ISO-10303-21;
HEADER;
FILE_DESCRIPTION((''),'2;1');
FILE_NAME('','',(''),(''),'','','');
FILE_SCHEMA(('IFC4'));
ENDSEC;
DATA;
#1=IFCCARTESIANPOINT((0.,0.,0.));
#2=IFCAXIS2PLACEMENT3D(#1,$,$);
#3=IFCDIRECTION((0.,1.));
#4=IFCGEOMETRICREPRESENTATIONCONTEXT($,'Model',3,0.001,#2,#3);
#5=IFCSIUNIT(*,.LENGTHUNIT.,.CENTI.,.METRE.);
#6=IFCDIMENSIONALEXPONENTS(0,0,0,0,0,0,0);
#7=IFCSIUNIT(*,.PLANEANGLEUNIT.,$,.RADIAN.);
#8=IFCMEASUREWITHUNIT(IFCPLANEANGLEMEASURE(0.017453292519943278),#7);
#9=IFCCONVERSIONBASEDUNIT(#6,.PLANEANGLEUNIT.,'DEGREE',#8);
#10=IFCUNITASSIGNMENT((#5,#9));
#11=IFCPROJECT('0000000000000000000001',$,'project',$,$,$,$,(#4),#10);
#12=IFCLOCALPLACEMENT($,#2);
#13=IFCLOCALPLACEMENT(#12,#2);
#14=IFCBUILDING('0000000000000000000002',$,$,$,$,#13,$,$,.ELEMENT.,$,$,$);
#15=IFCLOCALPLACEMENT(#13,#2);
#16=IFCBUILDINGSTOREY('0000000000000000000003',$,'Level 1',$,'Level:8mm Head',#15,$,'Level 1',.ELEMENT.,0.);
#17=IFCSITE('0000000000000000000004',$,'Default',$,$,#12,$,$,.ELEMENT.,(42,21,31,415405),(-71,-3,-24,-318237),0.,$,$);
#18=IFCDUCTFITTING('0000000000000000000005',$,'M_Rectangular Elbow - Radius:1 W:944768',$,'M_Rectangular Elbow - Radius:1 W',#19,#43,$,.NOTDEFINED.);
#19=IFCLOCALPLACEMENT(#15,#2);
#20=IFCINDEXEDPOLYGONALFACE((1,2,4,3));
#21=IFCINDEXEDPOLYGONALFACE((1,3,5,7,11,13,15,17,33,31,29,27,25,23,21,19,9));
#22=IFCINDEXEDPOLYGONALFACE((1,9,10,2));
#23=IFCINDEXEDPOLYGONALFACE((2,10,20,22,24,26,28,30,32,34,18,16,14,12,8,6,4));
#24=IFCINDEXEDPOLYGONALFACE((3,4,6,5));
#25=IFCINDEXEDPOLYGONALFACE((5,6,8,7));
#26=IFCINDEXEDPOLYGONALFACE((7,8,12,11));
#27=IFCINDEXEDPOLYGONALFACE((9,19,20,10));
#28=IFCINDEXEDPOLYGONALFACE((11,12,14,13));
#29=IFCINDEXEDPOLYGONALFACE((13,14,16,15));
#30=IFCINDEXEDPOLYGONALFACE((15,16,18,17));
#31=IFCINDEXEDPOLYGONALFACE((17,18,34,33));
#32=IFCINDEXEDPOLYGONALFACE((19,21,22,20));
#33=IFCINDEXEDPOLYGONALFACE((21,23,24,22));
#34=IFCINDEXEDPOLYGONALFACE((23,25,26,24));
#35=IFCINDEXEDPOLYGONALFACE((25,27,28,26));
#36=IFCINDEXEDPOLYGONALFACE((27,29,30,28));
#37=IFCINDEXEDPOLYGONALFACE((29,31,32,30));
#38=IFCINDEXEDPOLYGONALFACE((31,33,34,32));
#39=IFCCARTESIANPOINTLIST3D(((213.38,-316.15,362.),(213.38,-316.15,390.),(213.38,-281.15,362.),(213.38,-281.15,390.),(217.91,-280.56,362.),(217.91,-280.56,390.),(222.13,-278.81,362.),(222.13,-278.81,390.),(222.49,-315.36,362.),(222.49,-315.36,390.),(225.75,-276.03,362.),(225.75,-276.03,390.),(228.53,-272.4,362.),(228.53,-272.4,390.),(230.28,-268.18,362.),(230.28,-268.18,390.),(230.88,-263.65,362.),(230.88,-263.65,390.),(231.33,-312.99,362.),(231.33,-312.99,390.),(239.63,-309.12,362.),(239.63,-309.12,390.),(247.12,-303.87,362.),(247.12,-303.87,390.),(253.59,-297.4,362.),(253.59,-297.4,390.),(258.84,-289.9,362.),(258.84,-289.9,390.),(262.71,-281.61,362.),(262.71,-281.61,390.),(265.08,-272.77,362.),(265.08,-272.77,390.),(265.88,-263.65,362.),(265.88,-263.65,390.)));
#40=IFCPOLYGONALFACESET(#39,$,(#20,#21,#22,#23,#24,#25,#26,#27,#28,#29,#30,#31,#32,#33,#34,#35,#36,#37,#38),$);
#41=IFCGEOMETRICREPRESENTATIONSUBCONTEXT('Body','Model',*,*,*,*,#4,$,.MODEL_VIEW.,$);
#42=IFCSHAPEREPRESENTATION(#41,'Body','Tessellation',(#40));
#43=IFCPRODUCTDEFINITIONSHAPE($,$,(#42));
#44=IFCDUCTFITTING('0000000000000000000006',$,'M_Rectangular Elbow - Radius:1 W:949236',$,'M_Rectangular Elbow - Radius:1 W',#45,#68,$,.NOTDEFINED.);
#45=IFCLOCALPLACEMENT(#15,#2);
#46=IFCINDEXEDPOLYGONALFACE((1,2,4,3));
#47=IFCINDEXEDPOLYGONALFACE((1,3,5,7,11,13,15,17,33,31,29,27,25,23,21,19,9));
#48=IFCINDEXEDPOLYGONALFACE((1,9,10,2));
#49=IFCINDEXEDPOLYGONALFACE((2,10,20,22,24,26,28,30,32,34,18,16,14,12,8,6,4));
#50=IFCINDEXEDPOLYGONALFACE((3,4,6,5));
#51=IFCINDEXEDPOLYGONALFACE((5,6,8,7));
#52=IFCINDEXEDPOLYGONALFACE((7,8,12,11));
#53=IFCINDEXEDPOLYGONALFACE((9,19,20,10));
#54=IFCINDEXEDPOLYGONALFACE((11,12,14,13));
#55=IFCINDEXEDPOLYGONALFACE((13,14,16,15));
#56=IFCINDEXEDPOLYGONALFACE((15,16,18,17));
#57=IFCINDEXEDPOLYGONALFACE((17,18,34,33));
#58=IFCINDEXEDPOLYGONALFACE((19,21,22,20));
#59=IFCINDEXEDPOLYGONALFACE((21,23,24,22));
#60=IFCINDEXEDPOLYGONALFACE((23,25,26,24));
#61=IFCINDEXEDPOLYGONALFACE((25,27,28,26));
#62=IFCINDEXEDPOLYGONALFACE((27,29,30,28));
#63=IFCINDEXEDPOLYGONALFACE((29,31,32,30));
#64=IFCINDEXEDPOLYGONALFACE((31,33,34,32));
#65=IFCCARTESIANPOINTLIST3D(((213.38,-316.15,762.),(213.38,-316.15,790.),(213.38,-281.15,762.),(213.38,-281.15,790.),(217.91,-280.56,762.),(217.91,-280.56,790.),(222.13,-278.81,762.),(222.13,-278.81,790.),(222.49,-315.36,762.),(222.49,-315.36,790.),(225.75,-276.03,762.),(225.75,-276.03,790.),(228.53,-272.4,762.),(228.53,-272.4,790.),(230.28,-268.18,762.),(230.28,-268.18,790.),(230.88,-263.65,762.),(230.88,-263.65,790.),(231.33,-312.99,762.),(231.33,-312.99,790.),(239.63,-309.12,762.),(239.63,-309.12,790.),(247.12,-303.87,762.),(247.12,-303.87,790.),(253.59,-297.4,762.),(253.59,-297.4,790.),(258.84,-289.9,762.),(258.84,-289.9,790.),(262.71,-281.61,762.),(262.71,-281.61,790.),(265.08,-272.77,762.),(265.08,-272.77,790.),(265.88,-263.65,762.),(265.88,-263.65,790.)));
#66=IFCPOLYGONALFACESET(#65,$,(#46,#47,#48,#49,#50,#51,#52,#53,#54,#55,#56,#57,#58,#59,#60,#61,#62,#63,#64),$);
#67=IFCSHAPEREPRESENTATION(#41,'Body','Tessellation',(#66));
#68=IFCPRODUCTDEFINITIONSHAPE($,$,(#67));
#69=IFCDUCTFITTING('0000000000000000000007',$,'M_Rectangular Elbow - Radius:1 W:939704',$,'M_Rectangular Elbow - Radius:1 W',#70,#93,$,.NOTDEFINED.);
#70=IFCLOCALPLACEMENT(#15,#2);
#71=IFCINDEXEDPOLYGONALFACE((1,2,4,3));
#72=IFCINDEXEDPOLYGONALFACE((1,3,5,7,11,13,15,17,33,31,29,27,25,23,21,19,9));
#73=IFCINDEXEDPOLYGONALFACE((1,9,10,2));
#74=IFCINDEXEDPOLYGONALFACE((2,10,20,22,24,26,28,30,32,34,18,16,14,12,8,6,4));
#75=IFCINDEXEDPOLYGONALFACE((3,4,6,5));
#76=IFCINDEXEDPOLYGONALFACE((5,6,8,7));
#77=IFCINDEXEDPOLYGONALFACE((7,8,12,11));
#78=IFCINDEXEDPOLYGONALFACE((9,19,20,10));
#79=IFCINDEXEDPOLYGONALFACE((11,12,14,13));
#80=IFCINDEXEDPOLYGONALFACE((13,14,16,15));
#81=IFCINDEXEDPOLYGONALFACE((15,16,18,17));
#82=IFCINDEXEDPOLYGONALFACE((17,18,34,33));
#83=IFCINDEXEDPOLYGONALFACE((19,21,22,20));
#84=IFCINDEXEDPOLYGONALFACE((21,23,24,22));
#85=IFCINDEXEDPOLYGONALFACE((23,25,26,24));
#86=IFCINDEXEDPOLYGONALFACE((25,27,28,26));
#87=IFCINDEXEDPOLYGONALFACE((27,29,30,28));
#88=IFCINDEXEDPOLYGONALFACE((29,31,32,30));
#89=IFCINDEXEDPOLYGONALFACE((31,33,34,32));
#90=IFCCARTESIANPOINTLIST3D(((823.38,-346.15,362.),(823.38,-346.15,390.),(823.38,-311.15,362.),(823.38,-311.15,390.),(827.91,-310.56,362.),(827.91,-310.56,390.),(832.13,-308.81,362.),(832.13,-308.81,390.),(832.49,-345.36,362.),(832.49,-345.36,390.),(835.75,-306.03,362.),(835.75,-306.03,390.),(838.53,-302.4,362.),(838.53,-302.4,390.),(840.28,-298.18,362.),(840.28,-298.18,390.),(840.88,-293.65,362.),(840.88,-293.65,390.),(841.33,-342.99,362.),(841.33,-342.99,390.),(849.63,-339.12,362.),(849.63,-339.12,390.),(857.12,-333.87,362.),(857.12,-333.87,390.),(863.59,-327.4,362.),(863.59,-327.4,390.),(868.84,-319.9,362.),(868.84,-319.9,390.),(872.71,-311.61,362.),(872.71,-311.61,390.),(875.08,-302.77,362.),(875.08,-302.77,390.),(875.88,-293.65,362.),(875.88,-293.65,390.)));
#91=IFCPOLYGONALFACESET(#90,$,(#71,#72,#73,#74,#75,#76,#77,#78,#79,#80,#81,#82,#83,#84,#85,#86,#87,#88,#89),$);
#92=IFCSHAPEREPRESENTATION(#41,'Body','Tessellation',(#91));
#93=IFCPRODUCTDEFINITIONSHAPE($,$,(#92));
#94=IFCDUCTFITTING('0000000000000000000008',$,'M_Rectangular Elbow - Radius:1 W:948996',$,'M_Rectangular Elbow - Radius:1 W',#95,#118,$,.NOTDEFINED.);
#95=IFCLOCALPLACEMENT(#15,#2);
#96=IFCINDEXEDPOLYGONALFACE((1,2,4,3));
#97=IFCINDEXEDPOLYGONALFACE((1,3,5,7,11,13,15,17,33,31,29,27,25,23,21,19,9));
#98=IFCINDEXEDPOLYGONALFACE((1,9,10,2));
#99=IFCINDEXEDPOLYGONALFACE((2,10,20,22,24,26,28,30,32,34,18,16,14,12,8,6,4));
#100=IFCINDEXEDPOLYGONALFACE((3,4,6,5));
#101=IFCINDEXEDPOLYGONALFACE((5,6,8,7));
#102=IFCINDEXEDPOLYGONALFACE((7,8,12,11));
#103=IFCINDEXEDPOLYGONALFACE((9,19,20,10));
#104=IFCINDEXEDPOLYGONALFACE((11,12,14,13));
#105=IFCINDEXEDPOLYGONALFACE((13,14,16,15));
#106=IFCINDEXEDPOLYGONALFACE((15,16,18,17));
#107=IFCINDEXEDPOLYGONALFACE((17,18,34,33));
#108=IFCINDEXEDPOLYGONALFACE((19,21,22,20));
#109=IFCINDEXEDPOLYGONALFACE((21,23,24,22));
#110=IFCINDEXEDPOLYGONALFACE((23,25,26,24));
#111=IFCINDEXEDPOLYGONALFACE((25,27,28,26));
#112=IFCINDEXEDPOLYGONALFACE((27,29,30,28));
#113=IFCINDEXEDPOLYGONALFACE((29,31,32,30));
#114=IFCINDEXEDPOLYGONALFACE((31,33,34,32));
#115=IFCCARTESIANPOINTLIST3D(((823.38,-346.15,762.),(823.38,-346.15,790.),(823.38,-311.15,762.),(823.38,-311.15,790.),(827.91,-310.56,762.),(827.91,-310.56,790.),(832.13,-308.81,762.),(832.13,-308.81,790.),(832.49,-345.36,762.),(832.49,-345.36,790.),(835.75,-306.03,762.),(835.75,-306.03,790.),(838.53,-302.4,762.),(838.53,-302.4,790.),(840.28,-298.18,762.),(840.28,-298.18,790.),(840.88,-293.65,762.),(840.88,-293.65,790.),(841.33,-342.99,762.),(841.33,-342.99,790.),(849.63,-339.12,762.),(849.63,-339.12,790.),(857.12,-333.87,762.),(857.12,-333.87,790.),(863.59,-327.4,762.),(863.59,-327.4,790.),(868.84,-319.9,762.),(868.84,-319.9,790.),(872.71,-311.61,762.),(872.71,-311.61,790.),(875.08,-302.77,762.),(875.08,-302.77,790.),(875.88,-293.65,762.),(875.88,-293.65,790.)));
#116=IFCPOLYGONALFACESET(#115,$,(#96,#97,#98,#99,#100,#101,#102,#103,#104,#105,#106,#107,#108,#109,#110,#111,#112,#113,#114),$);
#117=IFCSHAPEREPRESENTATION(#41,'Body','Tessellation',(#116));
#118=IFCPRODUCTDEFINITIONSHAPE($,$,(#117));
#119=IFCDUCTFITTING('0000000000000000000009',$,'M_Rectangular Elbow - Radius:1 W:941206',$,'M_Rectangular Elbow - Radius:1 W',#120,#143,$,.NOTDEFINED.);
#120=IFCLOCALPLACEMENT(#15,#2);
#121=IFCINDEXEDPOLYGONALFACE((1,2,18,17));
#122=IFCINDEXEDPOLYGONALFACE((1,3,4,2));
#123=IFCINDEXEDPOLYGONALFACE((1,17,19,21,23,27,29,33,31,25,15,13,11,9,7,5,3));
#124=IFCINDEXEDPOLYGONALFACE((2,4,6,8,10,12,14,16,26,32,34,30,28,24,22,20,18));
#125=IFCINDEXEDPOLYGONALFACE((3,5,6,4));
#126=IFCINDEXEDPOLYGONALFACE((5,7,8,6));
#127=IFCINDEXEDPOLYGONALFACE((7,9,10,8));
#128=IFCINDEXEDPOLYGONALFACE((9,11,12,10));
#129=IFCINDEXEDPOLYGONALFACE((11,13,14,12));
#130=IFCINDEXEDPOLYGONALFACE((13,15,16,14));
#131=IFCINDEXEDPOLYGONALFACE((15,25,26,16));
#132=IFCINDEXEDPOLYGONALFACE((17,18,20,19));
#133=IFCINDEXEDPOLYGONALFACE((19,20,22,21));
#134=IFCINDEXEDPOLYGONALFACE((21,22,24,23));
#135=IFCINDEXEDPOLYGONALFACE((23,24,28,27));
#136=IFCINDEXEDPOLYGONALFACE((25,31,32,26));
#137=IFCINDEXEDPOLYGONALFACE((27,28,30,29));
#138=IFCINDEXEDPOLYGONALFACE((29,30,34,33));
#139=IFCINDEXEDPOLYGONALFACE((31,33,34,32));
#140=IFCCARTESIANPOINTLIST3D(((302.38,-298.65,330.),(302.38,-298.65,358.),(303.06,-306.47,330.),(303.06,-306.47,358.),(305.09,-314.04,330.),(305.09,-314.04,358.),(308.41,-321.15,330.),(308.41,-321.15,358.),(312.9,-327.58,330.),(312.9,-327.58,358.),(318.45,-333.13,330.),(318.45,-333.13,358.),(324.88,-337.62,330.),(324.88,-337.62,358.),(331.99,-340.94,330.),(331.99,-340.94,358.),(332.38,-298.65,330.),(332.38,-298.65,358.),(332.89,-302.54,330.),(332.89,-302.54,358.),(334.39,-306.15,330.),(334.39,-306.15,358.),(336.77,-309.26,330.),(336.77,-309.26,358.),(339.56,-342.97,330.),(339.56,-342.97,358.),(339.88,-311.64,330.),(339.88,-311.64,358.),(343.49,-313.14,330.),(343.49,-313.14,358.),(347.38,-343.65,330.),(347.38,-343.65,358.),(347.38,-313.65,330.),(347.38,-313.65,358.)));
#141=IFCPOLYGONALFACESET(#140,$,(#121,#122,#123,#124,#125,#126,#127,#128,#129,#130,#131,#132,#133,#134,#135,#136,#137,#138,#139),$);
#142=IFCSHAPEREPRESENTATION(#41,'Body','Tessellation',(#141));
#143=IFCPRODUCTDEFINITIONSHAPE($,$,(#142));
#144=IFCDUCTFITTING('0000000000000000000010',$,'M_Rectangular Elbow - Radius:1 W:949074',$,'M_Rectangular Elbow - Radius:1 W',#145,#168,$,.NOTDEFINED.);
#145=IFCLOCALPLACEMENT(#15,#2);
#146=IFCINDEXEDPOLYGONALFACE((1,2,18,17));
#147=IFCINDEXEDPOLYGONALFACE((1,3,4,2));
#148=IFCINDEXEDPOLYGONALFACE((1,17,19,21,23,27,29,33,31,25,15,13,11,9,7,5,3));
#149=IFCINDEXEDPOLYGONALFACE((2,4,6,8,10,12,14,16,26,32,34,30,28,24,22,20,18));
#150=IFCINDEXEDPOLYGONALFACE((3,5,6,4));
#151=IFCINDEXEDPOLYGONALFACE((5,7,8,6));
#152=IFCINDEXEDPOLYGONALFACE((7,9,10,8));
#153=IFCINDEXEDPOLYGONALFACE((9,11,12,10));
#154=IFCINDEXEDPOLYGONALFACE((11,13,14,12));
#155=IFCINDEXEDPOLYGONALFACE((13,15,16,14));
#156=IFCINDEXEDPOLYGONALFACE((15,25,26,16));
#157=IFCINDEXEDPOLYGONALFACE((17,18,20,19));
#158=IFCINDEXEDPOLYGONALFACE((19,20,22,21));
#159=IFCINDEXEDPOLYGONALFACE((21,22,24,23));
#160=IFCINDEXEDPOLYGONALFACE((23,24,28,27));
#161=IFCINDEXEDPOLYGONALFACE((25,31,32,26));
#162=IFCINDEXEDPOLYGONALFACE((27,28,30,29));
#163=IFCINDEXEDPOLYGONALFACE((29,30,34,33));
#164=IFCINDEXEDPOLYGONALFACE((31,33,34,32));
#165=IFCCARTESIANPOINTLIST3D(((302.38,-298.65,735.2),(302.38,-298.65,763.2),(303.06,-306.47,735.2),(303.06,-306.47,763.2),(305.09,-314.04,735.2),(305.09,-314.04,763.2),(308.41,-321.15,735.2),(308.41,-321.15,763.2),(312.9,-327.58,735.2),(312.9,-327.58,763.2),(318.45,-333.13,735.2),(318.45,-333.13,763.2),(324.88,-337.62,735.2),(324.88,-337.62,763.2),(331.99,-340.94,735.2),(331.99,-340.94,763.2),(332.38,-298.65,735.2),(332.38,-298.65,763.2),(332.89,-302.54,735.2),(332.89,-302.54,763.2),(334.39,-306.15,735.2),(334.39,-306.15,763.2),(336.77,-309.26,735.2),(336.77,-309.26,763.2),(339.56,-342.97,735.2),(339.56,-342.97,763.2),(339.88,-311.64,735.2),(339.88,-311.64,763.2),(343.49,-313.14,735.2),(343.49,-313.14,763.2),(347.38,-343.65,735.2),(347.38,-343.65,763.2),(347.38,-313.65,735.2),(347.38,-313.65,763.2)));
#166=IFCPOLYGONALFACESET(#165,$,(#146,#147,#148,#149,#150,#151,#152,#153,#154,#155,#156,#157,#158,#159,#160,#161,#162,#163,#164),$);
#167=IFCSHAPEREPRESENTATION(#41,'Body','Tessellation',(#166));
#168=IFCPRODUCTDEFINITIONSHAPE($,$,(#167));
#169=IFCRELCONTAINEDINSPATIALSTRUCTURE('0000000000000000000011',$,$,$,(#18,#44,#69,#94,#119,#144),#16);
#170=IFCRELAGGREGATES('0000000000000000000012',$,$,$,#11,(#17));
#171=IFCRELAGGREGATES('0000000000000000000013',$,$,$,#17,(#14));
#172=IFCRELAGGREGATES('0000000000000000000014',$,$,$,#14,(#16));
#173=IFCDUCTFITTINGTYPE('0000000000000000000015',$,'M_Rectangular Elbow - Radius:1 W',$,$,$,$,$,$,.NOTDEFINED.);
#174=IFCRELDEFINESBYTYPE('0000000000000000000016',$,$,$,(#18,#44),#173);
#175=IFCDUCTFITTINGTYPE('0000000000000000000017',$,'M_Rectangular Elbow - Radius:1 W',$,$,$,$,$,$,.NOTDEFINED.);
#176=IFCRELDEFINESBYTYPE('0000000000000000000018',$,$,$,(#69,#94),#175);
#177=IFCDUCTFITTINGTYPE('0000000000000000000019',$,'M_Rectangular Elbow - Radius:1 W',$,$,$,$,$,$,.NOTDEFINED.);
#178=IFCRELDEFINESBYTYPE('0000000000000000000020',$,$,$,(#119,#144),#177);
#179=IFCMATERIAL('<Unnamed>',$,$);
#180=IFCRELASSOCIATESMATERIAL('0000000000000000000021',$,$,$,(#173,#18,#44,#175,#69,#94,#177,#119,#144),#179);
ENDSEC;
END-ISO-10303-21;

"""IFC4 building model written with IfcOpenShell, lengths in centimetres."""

from ifc_helpers import new_model, entity, si_unit, converted_unit, direction, frame, origin, place, context, subcontext, project, spatial, line, arc, indexed_curve, outline, extrude, source, transform, mapped, material, type_object, type_shapes, element, save


model = new_model("IFC4")

# Units and contexts
model_context = context("Model", 3, precision=0.001, world=origin(), true_north=direction((0.0, 1.0)))
body_context = subcontext(model_context, "Body", "Model", "MODEL_VIEW")
ifc_project = project(units=[si_unit("LENGTHUNIT", "METRE", prefix="CENTI"), converted_unit("PLANEANGLEUNIT", "DEGREE", entity("IfcPlaneAngleMeasure", 0.017453292519943278), si_unit("PLANEANGLEUNIT", "RADIAN"), dimensions=[0, 0, 0, 0, 0, 0, 0])], contexts=[model_context])

# Site, building, storey
site_placement = place(None, origin())
site = spatial("IfcSite", under=ifc_project, at=site_placement, Name="Default", CompositionType="ELEMENT", RefLatitude=(42, 21, 31, 415405), RefLongitude=(-71, -3, -24, -318237), RefElevation=0.0)
building_placement = place(site_placement, origin())
building = spatial("IfcBuilding", under=site, at=building_placement, CompositionType="ELEMENT")
storey_placement = place(building_placement, origin())
storey = spatial("IfcBuildingStorey", under=building, at=storey_placement, Name="Level 1", ObjectType="Level:8mm Head", LongName="Level 1", CompositionType="ELEMENT", Elevation=0.0)

# Duct fittings
ifc_material = material(Name="<Unnamed>")
duct_fitting_type_1 = type_object("IfcDuctFittingType", Name="M_Rectangular Elbow - Radius:1 W", PredefinedType="NOTDEFINED", material=ifc_material)
shared_shape_1 = source(origin(), body_context, "Body", "SweptSolid", [
    extrude(outline(indexed_curve([(-35.0, -17.5), (0.0, -17.5), (5.13, -5.13), (17.5, 0.0), (17.5, 35.0), (-19.62, 19.62)], segments=[line(1, 2), arc(2, 3, 4), line(4, 5), arc(5, 6, 1)], self_intersect=False)), frame((-17.5, 17.5, -14.0), z_axis=(0.0, 0.0, 1.0), x_axis=(-1.0, 0.0, 0.0)), (0.0, 0.0, 1.0), 28.0),
])
type_shapes(duct_fitting_type_1, [shared_shape_1])
for number, where, name in (
    (1, (248.38, -298.65, 376.0), "M_Rectangular Elbow - Radius:1 W:944768"),
    (2, (248.38, -298.65, 776.0), "M_Rectangular Elbow - Radius:1 W:949236"),
):
    element("IfcDuctFitting", number, at=place(storey_placement, frame(where)), inside=storey, type_object=duct_fitting_type_1, material=ifc_material, Name=name, ObjectType="M_Rectangular Elbow - Radius:1 W", PredefinedType="NOTDEFINED", context=body_context, shape_type="MappedRepresentation", body=[
        mapped(shared_shape_1, transform((0.0, 0.0, 0.0), scale=1.0)),
    ])
duct_fitting_type_2 = type_object("IfcDuctFittingType", Name="M_Rectangular Elbow - Radius:1 W", PredefinedType="NOTDEFINED", material=ifc_material)
shared_shape_2 = source(origin(), body_context, "Body", "SweptSolid", [
    extrude(outline(indexed_curve([(-17.5, -35.0), (19.62, -19.62), (35.0, 17.5), (0.0, 17.5), (-5.13, 5.13), (-17.5, 0.0)], segments=[arc(1, 2, 3), line(3, 4), arc(4, 5, 6), line(6, 1)], self_intersect=False)), frame((-17.5, -17.5, -14.0), z_axis=(0.0, 0.0, 1.0), x_axis=(0.0, 1.0, 0.0)), (0.0, 0.0, 1.0), 28.0),
])
type_shapes(duct_fitting_type_2, [shared_shape_2])
for number, where, z_axis, x_axis, name in (
    (3, (858.38, -328.65, 376.0), (0.0, 0.0, 1.0), (0.0, -1.0, 0.0), "M_Rectangular Elbow - Radius:1 W:939704"),
    (4, (858.38, -328.65, 776.0), (0.0, 0.0, 1.0), (0.0, -1.0, 0.0), "M_Rectangular Elbow - Radius:1 W:948996"),
):
    element("IfcDuctFitting", number, at=place(storey_placement, frame(where, z_axis=z_axis, x_axis=x_axis)), inside=storey, type_object=duct_fitting_type_2, material=ifc_material, Name=name, ObjectType="M_Rectangular Elbow - Radius:1 W", PredefinedType="NOTDEFINED", context=body_context, shape_type="MappedRepresentation", body=[
        mapped(shared_shape_2, transform((0.0, 0.0, 0.0), scale=1.0)),
    ])
duct_fitting_type_3 = type_object("IfcDuctFittingType", Name="M_Rectangular Elbow - Radius:1 W", PredefinedType="NOTDEFINED", material=ifc_material)
shared_shape_3 = source(origin(), body_context, "Body", "SweptSolid", [
    extrude(outline(indexed_curve([(-15.0, -30.0), (16.82, -16.82), (30.0, 15.0), (0.0, 15.0), (-4.39, 4.39), (-15.0, 0.0)], segments=[arc(1, 2, 3), line(3, 4), arc(4, 5, 6), line(6, 1)], self_intersect=False)), frame((-15.0, -15.0, -14.0), z_axis=(0.0, 0.0, 1.0), x_axis=(0.0, 1.0, 0.0)), (0.0, 0.0, 1.0), 28.0),
])
type_shapes(duct_fitting_type_3, [shared_shape_3])
for number, where, z_axis, x_axis, name in (
    (5, (317.38, -328.65, 344.0), (0.0, 0.0, 1.0), (-1.0, 0.0, 0.0), "M_Rectangular Elbow - Radius:1 W:941206"),
    (6, (317.38, -328.65, 749.2), (0.0, 0.0, 1.0), (-1.0, 0.0, 0.0), "M_Rectangular Elbow - Radius:1 W:949074"),
):
    element("IfcDuctFitting", number, at=place(storey_placement, frame(where, z_axis=z_axis, x_axis=x_axis)), inside=storey, type_object=duct_fitting_type_3, material=ifc_material, Name=name, ObjectType="M_Rectangular Elbow - Radius:1 W", PredefinedType="NOTDEFINED", context=body_context, shape_type="MappedRepresentation", body=[
        mapped(shared_shape_3, transform((0.0, 0.0, 0.0), scale=1.0)),
    ])

save(model, "model.ifc")
